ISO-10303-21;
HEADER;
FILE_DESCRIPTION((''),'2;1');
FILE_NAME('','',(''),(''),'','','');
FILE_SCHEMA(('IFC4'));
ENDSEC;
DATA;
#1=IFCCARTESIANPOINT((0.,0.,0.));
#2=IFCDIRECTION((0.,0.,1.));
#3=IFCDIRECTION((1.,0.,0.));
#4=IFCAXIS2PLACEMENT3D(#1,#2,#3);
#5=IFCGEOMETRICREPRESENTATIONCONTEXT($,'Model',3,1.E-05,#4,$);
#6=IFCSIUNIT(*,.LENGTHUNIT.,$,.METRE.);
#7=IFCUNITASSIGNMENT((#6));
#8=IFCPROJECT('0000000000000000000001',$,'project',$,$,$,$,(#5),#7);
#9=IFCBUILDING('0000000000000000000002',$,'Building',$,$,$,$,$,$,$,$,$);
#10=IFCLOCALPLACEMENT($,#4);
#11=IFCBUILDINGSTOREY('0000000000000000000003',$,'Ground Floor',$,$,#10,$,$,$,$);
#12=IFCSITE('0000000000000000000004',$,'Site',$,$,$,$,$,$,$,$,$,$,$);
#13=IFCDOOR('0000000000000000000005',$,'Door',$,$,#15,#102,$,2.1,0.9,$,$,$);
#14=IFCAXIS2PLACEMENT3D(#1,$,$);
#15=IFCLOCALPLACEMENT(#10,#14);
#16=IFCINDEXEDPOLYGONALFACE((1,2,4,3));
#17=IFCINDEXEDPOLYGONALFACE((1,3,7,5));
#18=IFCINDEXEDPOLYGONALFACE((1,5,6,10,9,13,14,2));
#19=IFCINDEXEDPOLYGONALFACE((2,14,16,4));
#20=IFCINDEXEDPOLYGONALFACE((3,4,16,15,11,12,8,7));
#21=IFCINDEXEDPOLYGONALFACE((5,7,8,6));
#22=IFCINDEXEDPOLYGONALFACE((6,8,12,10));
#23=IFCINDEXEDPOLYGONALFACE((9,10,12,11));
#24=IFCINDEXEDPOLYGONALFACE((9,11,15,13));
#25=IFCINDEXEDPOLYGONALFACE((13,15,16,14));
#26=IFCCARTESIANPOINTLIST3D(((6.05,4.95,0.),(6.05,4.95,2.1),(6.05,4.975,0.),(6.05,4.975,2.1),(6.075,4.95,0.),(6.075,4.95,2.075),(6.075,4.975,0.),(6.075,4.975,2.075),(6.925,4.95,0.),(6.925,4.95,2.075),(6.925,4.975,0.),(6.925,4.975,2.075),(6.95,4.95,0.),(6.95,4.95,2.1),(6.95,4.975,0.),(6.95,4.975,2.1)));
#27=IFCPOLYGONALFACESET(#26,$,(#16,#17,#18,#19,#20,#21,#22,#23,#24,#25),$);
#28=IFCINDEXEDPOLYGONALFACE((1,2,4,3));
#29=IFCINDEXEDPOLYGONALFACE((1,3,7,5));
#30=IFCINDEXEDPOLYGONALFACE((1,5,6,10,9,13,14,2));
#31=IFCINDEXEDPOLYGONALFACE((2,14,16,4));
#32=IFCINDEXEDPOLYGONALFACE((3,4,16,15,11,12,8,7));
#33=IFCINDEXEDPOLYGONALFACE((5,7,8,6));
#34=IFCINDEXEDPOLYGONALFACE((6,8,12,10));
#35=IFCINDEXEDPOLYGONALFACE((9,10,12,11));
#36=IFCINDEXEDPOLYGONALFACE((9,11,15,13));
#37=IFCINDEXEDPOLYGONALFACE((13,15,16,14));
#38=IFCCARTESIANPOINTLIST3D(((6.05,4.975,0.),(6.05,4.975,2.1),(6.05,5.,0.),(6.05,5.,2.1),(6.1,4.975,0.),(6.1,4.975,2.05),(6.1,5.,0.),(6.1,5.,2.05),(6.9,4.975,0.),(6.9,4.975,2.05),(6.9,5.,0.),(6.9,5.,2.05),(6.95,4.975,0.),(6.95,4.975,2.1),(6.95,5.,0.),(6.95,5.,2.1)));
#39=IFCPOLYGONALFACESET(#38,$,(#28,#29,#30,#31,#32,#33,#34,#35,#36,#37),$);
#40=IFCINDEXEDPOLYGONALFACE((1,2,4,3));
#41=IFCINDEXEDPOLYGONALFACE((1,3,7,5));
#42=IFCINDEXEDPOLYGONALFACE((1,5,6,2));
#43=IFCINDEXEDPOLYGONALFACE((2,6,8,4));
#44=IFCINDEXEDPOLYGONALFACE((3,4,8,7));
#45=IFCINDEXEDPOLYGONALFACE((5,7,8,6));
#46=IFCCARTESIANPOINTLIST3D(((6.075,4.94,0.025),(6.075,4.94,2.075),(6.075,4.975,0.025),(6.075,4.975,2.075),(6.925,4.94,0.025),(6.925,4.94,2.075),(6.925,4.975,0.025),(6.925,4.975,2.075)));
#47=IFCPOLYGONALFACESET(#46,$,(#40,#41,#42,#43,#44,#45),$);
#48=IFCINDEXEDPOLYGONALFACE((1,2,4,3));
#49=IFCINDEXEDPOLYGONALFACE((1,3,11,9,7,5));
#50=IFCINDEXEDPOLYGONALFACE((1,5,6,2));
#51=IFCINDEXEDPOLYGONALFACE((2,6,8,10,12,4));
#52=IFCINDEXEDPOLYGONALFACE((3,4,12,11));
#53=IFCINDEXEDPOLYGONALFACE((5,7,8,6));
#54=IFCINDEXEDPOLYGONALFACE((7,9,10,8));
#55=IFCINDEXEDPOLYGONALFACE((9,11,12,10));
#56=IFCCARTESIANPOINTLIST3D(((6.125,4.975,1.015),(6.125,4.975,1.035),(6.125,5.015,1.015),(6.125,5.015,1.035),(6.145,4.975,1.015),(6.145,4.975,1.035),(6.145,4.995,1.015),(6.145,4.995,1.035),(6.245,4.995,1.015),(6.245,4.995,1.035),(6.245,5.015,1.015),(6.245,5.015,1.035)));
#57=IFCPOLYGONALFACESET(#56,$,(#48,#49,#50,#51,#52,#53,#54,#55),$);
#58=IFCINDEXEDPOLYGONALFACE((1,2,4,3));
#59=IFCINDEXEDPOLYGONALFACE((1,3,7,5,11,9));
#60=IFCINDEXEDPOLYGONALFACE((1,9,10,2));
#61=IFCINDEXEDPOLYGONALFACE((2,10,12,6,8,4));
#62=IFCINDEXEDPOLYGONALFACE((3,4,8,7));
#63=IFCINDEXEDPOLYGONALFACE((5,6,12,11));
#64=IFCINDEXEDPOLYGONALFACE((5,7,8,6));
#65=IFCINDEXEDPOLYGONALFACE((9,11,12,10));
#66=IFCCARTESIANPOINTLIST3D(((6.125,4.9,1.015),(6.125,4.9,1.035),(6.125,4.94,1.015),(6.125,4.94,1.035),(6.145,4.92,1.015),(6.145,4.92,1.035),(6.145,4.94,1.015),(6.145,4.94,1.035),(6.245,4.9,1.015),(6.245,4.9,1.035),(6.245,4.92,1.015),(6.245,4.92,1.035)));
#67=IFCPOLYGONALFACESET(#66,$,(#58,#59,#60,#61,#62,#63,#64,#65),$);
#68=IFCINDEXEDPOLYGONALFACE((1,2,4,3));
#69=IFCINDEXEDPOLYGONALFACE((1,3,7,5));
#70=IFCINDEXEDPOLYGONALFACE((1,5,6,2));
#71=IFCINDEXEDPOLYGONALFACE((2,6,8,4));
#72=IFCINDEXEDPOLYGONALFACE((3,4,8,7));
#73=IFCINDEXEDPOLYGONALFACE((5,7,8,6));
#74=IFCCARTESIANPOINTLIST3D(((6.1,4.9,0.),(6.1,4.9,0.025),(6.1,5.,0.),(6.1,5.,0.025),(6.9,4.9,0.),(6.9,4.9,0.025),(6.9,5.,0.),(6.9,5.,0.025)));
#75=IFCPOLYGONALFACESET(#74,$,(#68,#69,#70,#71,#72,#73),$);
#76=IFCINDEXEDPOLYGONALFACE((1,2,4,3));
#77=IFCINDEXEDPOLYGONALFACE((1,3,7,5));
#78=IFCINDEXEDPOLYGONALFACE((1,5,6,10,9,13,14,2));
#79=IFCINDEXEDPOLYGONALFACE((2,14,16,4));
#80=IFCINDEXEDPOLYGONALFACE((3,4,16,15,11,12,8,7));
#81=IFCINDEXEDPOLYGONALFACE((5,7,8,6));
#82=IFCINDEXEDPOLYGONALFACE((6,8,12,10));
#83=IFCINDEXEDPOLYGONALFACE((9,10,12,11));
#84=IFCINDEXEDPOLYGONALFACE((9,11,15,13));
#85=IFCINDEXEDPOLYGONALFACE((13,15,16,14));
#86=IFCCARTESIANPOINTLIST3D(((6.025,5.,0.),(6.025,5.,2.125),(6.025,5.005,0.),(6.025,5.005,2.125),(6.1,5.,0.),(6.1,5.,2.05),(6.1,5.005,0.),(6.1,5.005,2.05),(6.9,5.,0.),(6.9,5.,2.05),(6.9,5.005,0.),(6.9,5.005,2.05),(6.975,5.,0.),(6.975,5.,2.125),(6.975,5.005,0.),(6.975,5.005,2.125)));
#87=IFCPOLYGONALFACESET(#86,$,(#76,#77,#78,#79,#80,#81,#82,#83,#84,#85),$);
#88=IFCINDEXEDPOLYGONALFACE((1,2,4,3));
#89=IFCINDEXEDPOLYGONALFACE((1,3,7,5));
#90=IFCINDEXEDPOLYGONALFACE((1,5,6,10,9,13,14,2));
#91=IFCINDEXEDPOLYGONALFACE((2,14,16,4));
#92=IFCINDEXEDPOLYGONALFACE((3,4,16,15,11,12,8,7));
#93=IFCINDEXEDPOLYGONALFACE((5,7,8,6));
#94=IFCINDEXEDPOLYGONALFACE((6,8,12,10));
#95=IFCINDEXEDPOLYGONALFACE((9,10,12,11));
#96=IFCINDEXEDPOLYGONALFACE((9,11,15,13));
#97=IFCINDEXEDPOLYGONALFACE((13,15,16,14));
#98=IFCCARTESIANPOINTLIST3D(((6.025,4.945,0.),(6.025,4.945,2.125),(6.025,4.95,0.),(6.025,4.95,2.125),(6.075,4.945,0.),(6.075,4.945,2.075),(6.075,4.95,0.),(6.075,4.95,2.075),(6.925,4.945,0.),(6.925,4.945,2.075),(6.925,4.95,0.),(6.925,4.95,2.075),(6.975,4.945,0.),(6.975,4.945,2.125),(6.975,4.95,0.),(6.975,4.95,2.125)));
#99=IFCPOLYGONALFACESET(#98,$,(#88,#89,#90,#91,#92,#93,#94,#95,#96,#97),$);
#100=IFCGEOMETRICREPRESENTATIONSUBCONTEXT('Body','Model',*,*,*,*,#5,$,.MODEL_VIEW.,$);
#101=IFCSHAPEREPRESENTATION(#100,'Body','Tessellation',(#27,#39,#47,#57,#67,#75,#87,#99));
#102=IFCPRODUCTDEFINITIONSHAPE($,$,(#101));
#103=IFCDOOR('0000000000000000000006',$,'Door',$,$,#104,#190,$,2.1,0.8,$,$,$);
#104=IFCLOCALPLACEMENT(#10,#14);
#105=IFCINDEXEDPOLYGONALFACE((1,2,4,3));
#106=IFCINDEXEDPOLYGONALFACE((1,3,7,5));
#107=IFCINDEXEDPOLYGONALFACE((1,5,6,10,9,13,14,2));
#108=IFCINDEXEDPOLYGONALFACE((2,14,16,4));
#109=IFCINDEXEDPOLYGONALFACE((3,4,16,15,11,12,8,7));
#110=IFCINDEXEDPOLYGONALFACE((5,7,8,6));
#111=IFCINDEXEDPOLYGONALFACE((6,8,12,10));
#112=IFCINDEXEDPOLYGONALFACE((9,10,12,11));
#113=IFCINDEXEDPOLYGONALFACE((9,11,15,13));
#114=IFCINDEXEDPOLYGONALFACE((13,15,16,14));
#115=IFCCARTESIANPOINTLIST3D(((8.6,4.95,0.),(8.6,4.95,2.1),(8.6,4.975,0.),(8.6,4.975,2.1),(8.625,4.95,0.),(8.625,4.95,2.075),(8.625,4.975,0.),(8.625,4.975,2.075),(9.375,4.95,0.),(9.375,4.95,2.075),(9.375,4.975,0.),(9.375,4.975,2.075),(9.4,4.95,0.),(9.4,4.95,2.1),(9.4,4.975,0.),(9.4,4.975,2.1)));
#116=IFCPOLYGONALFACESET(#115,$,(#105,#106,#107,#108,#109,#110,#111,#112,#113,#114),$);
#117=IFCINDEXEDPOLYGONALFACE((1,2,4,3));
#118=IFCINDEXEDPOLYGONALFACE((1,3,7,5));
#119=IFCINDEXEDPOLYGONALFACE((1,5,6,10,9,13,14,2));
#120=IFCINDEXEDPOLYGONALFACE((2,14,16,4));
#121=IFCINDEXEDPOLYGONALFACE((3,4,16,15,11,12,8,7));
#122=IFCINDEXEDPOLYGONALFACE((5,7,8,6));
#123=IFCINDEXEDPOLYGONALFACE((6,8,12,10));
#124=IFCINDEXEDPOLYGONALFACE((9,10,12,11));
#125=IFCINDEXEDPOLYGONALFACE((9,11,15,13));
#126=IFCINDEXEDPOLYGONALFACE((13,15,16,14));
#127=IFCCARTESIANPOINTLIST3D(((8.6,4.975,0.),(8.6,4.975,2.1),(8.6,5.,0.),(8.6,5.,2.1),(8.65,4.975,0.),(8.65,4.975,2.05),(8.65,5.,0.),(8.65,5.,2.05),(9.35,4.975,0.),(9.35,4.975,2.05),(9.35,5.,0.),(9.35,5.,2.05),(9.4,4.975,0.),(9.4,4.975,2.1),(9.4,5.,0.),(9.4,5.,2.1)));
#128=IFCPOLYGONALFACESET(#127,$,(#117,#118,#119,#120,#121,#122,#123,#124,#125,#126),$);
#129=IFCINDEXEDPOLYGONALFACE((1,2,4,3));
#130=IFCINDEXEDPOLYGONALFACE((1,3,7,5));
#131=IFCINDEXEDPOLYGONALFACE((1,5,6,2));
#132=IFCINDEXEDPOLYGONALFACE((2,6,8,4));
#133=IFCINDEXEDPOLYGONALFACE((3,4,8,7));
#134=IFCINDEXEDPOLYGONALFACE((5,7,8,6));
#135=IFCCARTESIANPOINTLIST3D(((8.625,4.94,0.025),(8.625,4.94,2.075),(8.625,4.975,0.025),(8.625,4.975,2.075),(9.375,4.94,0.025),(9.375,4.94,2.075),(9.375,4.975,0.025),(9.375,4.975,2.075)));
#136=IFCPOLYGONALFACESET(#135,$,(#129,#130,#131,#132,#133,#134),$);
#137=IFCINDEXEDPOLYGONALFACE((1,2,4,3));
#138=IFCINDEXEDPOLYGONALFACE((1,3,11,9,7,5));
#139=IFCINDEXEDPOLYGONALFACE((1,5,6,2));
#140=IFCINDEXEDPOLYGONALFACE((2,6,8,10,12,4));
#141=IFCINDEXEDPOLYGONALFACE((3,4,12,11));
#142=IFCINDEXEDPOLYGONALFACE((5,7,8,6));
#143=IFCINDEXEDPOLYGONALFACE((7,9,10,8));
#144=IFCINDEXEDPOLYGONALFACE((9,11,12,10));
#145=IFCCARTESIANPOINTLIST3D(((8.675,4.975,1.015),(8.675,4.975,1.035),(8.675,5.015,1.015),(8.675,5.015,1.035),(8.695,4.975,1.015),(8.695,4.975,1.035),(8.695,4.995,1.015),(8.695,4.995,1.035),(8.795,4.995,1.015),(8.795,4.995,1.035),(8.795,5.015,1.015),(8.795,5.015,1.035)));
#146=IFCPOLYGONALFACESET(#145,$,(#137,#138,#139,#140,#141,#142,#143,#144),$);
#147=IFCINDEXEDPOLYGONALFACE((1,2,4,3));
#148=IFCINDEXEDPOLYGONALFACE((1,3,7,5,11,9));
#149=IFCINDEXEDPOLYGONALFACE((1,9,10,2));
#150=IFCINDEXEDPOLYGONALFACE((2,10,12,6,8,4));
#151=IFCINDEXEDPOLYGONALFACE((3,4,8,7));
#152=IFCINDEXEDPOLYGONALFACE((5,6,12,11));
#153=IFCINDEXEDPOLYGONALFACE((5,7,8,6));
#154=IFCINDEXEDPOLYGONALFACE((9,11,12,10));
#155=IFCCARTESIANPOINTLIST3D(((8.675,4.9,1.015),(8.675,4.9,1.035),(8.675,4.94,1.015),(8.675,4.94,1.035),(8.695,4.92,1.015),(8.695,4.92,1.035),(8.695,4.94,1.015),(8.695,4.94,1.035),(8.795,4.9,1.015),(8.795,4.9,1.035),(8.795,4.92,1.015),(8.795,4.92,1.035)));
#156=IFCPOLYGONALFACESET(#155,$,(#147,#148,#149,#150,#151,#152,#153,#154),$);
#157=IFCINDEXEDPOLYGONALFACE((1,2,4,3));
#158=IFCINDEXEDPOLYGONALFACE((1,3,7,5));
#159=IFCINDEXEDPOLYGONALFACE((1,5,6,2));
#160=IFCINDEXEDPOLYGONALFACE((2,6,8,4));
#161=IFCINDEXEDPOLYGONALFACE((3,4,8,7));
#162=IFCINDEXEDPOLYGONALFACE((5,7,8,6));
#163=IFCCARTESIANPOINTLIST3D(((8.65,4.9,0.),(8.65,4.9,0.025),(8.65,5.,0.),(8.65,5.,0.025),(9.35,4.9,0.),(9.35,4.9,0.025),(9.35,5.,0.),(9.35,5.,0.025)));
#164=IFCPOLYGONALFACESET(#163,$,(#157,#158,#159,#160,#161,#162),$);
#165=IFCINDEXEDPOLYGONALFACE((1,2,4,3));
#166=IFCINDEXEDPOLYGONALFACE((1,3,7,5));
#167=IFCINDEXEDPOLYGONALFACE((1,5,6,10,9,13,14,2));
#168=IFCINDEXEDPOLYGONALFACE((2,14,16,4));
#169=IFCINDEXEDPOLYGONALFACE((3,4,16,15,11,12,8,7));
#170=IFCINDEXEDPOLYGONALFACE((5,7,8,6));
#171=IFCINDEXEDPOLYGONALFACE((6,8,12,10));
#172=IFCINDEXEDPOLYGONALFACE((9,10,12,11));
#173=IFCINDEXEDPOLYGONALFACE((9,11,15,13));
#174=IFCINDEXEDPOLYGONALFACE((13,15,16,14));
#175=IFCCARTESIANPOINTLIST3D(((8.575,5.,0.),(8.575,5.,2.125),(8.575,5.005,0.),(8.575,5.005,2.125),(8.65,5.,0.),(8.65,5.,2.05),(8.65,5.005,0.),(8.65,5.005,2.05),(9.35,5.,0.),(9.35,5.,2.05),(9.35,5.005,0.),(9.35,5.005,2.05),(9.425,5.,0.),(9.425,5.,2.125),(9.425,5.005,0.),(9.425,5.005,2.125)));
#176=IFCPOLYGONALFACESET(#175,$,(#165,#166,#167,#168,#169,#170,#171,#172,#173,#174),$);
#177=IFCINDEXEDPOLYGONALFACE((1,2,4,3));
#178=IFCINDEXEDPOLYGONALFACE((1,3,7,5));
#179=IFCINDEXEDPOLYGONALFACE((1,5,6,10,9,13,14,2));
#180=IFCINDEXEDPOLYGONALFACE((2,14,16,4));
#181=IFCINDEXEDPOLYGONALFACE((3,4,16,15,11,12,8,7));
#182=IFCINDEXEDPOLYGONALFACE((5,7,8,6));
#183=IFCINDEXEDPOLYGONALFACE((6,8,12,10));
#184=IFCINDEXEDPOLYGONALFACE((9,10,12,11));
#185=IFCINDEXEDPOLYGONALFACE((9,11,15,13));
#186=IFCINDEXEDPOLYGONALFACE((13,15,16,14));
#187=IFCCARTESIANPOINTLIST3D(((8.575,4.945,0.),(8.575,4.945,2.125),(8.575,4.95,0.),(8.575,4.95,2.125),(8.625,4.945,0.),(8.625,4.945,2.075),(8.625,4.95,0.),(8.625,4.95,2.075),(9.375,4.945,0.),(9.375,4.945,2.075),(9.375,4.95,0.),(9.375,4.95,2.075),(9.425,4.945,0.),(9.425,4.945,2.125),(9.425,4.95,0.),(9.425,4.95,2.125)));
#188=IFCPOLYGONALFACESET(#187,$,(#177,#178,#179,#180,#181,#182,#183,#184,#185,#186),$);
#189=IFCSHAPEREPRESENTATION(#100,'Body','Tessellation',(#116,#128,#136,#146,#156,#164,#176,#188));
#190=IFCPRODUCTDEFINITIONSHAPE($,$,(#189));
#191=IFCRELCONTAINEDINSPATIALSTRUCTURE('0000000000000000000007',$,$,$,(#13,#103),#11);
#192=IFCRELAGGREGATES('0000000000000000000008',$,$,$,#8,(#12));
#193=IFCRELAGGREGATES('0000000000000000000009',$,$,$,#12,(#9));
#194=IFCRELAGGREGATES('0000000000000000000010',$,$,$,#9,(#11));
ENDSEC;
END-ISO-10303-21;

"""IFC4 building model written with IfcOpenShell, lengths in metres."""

from ifc_helpers import new_model, si_unit, frame, origin_with_axes, place, context, subcontext, project, spatial, line, indexed_curve, outline, extrude, element, save


model = new_model("IFC4")

# Units and contexts
model_context = context("Model", 3, precision=1e-05, world=origin_with_axes())
body_context = subcontext(model_context, "Body", "Model", "MODEL_VIEW")
ifc_project = project(units=[si_unit("LENGTHUNIT", "METRE")], contexts=[model_context])

# Site, building, storey
site = spatial("IfcSite", under=ifc_project, Name="Site")
building = spatial("IfcBuilding", under=site, Name="Building")
storey_placement = place(None, origin_with_axes())
storey = spatial("IfcBuildingStorey", under=building, at=storey_placement, Name="Ground Floor")

# Doors
door_1_placement = place(storey_placement, frame((6.95, 5.0, 0.0), z_axis=(0.0, 0.0, 1.0), x_axis=(-1.0, 0.0, 0.0)))
element("IfcDoor", 1, at=door_1_placement, inside=storey, Name="Door", OverallHeight=2.1, OverallWidth=0.9, context=body_context, shape_type="SweptSolid", body=[
    extrude(outline(indexed_curve([(0.0, 0.0), (0.0, 2.1), (0.9, 2.1), (0.9, 0.0), (0.875, 0.0), (0.875, 2.075), (0.025, 2.075), (0.025, 0.0)], segments=[line(1, 2, 3, 4, 5, 6, 7, 8, 1)])), frame((0.0, 0.025, 0.0), z_axis=(0.0, -1.0, 0.0), x_axis=(1.0, 0.0, 0.0)), (0.0, 0.0, -1.0), 0.025),
    extrude(outline(indexed_curve([(0.0, 0.0), (0.0, 2.1), (0.9, 2.1), (0.9, 0.0), (0.85, 0.0), (0.85, 2.05), (0.05, 2.05), (0.05, 0.0)], segments=[line(1, 2, 3, 4, 5, 6, 7, 8, 1)])), frame((0.0, 0.0, 0.0), z_axis=(0.0, -1.0, 0.0), x_axis=(1.0, 0.0, 0.0)), (0.0, 0.0, -1.0), 0.025),
    extrude(outline(indexed_curve([(0.0, 0.0), (0.85, 0.0), (0.85, 0.035), (0.0, 0.035)], segments=[line(1, 2, 3, 4, 1)])), frame((0.025, 0.025, 0.025), z_axis=(0.0, 0.0, 1.0), x_axis=(1.0, 0.0, 0.0)), (0.0, 0.0, 1.0), 2.05),
    extrude(outline(indexed_curve([(0.0, 0.0), (0.0, -0.04), (-0.12, -0.04), (-0.12, -0.02), (-0.02, -0.02), (-0.02, 0.0)], segments=[line(1, 2, 3, 4, 5, 6, 1)])), frame((0.825, 0.025, 1.015), z_axis=(0.0, 0.0, 1.0), x_axis=(1.0, 0.0, 0.0)), (0.0, 0.0, 1.0), 0.02),
    extrude(outline(indexed_curve([(0.0, 0.0), (0.0, 0.04), (-0.12, 0.04), (-0.12, 0.02), (-0.02, 0.02), (-0.02, 0.0)], segments=[line(1, 2, 3, 4, 5, 6, 1)])), frame((0.825, 0.06, 1.015), z_axis=(0.0, 0.0, 1.0), x_axis=(1.0, 0.0, 0.0)), (0.0, 0.0, 1.0), 0.02),
    extrude(outline(indexed_curve([(0.0, 0.0), (0.8, 0.0), (0.8, 0.1), (0.0, 0.1)], segments=[line(1, 2, 3, 4, 1)])), frame((0.05, 0.0, 0.0), z_axis=(0.0, 0.0, 1.0), x_axis=(1.0, 0.0, 0.0)), (0.0, 0.0, 1.0), 0.025),
    extrude(outline(indexed_curve([(0.0, 0.0), (0.0, 2.125), (0.95, 2.125), (0.95, 0.0), (0.875, 0.0), (0.875, 2.05), (0.075, 2.05), (0.075, 0.0)], segments=[line(1, 2, 3, 4, 5, 6, 7, 8, 1)])), frame((-0.025, -0.005, 0.0), z_axis=(0.0, -1.0, 0.0), x_axis=(1.0, 0.0, 0.0)), (0.0, 0.0, -1.0), 0.005),
    extrude(outline(indexed_curve([(0.0, 0.0), (0.0, 2.125), (0.95, 2.125), (0.95, 0.0), (0.9, 0.0), (0.9, 2.075), (0.05, 2.075), (0.05, 0.0)], segments=[line(1, 2, 3, 4, 5, 6, 7, 8, 1)])), frame((-0.025, 0.05, 0.0), z_axis=(0.0, -1.0, 0.0), x_axis=(1.0, 0.0, 0.0)), (0.0, 0.0, -1.0), 0.005),
])
door_2_placement = place(storey_placement, frame((9.4, 5.0, 0.0), z_axis=(0.0, 0.0, 1.0), x_axis=(-1.0, 0.0, 0.0)))
element("IfcDoor", 2, at=door_2_placement, inside=storey, Name="Door", OverallHeight=2.1, OverallWidth=0.8, context=body_context, shape_type="SweptSolid", body=[
    extrude(outline(indexed_curve([(0.0, 0.0), (0.0, 2.1), (0.8, 2.1), (0.8, 0.0), (0.775, 0.0), (0.775, 2.075), (0.025, 2.075), (0.025, 0.0)], segments=[line(1, 2, 3, 4, 5, 6, 7, 8, 1)])), frame((0.0, 0.025, 0.0), z_axis=(0.0, -1.0, 0.0), x_axis=(1.0, 0.0, 0.0)), (0.0, 0.0, -1.0), 0.025),
    extrude(outline(indexed_curve([(0.0, 0.0), (0.0, 2.1), (0.8, 2.1), (0.8, 0.0), (0.75, 0.0), (0.75, 2.05), (0.05, 2.05), (0.05, 0.0)], segments=[line(1, 2, 3, 4, 5, 6, 7, 8, 1)])), frame((0.0, 0.0, 0.0), z_axis=(0.0, -1.0, 0.0), x_axis=(1.0, 0.0, 0.0)), (0.0, 0.0, -1.0), 0.025),
    extrude(outline(indexed_curve([(0.0, 0.0), (0.75, 0.0), (0.75, 0.035), (0.0, 0.035)], segments=[line(1, 2, 3, 4, 1)])), frame((0.025, 0.025, 0.025), z_axis=(0.0, 0.0, 1.0), x_axis=(1.0, 0.0, 0.0)), (0.0, 0.0, 1.0), 2.05),
    extrude(outline(indexed_curve([(0.0, 0.0), (0.0, -0.04), (-0.12, -0.04), (-0.12, -0.02), (-0.02, -0.02), (-0.02, 0.0)], segments=[line(1, 2, 3, 4, 5, 6, 1)])), frame((0.725, 0.025, 1.015), z_axis=(0.0, 0.0, 1.0), x_axis=(1.0, 0.0, 0.0)), (0.0, 0.0, 1.0), 0.02),
    extrude(outline(indexed_curve([(0.0, 0.0), (0.0, 0.04), (-0.12, 0.04), (-0.12, 0.02), (-0.02, 0.02), (-0.02, 0.0)], segments=[line(1, 2, 3, 4, 5, 6, 1)])), frame((0.725, 0.06, 1.015), z_axis=(0.0, 0.0, 1.0), x_axis=(1.0, 0.0, 0.0)), (0.0, 0.0, 1.0), 0.02),
    extrude(outline(indexed_curve([(0.0, 0.0), (0.7, 0.0), (0.7, 0.1), (0.0, 0.1)], segments=[line(1, 2, 3, 4, 1)])), frame((0.05, 0.0, 0.0), z_axis=(0.0, 0.0, 1.0), x_axis=(1.0, 0.0, 0.0)), (0.0, 0.0, 1.0), 0.025),
    extrude(outline(indexed_curve([(0.0, 0.0), (0.0, 2.125), (0.85, 2.125), (0.85, 0.0), (0.775, 0.0), (0.775, 2.05), (0.075, 2.05), (0.075, 0.0)], segments=[line(1, 2, 3, 4, 5, 6, 7, 8, 1)])), frame((-0.025, -0.005, 0.0), z_axis=(0.0, -1.0, 0.0), x_axis=(1.0, 0.0, 0.0)), (0.0, 0.0, -1.0), 0.005),
    extrude(outline(indexed_curve([(0.0, 0.0), (0.0, 2.125), (0.85, 2.125), (0.85, 0.0), (0.8, 0.0), (0.8, 2.075), (0.05, 2.075), (0.05, 0.0)], segments=[line(1, 2, 3, 4, 5, 6, 7, 8, 1)])), frame((-0.025, 0.05, 0.0), z_axis=(0.0, -1.0, 0.0), x_axis=(1.0, 0.0, 0.0)), (0.0, 0.0, -1.0), 0.005),
])

save(model, "model.ifc")
